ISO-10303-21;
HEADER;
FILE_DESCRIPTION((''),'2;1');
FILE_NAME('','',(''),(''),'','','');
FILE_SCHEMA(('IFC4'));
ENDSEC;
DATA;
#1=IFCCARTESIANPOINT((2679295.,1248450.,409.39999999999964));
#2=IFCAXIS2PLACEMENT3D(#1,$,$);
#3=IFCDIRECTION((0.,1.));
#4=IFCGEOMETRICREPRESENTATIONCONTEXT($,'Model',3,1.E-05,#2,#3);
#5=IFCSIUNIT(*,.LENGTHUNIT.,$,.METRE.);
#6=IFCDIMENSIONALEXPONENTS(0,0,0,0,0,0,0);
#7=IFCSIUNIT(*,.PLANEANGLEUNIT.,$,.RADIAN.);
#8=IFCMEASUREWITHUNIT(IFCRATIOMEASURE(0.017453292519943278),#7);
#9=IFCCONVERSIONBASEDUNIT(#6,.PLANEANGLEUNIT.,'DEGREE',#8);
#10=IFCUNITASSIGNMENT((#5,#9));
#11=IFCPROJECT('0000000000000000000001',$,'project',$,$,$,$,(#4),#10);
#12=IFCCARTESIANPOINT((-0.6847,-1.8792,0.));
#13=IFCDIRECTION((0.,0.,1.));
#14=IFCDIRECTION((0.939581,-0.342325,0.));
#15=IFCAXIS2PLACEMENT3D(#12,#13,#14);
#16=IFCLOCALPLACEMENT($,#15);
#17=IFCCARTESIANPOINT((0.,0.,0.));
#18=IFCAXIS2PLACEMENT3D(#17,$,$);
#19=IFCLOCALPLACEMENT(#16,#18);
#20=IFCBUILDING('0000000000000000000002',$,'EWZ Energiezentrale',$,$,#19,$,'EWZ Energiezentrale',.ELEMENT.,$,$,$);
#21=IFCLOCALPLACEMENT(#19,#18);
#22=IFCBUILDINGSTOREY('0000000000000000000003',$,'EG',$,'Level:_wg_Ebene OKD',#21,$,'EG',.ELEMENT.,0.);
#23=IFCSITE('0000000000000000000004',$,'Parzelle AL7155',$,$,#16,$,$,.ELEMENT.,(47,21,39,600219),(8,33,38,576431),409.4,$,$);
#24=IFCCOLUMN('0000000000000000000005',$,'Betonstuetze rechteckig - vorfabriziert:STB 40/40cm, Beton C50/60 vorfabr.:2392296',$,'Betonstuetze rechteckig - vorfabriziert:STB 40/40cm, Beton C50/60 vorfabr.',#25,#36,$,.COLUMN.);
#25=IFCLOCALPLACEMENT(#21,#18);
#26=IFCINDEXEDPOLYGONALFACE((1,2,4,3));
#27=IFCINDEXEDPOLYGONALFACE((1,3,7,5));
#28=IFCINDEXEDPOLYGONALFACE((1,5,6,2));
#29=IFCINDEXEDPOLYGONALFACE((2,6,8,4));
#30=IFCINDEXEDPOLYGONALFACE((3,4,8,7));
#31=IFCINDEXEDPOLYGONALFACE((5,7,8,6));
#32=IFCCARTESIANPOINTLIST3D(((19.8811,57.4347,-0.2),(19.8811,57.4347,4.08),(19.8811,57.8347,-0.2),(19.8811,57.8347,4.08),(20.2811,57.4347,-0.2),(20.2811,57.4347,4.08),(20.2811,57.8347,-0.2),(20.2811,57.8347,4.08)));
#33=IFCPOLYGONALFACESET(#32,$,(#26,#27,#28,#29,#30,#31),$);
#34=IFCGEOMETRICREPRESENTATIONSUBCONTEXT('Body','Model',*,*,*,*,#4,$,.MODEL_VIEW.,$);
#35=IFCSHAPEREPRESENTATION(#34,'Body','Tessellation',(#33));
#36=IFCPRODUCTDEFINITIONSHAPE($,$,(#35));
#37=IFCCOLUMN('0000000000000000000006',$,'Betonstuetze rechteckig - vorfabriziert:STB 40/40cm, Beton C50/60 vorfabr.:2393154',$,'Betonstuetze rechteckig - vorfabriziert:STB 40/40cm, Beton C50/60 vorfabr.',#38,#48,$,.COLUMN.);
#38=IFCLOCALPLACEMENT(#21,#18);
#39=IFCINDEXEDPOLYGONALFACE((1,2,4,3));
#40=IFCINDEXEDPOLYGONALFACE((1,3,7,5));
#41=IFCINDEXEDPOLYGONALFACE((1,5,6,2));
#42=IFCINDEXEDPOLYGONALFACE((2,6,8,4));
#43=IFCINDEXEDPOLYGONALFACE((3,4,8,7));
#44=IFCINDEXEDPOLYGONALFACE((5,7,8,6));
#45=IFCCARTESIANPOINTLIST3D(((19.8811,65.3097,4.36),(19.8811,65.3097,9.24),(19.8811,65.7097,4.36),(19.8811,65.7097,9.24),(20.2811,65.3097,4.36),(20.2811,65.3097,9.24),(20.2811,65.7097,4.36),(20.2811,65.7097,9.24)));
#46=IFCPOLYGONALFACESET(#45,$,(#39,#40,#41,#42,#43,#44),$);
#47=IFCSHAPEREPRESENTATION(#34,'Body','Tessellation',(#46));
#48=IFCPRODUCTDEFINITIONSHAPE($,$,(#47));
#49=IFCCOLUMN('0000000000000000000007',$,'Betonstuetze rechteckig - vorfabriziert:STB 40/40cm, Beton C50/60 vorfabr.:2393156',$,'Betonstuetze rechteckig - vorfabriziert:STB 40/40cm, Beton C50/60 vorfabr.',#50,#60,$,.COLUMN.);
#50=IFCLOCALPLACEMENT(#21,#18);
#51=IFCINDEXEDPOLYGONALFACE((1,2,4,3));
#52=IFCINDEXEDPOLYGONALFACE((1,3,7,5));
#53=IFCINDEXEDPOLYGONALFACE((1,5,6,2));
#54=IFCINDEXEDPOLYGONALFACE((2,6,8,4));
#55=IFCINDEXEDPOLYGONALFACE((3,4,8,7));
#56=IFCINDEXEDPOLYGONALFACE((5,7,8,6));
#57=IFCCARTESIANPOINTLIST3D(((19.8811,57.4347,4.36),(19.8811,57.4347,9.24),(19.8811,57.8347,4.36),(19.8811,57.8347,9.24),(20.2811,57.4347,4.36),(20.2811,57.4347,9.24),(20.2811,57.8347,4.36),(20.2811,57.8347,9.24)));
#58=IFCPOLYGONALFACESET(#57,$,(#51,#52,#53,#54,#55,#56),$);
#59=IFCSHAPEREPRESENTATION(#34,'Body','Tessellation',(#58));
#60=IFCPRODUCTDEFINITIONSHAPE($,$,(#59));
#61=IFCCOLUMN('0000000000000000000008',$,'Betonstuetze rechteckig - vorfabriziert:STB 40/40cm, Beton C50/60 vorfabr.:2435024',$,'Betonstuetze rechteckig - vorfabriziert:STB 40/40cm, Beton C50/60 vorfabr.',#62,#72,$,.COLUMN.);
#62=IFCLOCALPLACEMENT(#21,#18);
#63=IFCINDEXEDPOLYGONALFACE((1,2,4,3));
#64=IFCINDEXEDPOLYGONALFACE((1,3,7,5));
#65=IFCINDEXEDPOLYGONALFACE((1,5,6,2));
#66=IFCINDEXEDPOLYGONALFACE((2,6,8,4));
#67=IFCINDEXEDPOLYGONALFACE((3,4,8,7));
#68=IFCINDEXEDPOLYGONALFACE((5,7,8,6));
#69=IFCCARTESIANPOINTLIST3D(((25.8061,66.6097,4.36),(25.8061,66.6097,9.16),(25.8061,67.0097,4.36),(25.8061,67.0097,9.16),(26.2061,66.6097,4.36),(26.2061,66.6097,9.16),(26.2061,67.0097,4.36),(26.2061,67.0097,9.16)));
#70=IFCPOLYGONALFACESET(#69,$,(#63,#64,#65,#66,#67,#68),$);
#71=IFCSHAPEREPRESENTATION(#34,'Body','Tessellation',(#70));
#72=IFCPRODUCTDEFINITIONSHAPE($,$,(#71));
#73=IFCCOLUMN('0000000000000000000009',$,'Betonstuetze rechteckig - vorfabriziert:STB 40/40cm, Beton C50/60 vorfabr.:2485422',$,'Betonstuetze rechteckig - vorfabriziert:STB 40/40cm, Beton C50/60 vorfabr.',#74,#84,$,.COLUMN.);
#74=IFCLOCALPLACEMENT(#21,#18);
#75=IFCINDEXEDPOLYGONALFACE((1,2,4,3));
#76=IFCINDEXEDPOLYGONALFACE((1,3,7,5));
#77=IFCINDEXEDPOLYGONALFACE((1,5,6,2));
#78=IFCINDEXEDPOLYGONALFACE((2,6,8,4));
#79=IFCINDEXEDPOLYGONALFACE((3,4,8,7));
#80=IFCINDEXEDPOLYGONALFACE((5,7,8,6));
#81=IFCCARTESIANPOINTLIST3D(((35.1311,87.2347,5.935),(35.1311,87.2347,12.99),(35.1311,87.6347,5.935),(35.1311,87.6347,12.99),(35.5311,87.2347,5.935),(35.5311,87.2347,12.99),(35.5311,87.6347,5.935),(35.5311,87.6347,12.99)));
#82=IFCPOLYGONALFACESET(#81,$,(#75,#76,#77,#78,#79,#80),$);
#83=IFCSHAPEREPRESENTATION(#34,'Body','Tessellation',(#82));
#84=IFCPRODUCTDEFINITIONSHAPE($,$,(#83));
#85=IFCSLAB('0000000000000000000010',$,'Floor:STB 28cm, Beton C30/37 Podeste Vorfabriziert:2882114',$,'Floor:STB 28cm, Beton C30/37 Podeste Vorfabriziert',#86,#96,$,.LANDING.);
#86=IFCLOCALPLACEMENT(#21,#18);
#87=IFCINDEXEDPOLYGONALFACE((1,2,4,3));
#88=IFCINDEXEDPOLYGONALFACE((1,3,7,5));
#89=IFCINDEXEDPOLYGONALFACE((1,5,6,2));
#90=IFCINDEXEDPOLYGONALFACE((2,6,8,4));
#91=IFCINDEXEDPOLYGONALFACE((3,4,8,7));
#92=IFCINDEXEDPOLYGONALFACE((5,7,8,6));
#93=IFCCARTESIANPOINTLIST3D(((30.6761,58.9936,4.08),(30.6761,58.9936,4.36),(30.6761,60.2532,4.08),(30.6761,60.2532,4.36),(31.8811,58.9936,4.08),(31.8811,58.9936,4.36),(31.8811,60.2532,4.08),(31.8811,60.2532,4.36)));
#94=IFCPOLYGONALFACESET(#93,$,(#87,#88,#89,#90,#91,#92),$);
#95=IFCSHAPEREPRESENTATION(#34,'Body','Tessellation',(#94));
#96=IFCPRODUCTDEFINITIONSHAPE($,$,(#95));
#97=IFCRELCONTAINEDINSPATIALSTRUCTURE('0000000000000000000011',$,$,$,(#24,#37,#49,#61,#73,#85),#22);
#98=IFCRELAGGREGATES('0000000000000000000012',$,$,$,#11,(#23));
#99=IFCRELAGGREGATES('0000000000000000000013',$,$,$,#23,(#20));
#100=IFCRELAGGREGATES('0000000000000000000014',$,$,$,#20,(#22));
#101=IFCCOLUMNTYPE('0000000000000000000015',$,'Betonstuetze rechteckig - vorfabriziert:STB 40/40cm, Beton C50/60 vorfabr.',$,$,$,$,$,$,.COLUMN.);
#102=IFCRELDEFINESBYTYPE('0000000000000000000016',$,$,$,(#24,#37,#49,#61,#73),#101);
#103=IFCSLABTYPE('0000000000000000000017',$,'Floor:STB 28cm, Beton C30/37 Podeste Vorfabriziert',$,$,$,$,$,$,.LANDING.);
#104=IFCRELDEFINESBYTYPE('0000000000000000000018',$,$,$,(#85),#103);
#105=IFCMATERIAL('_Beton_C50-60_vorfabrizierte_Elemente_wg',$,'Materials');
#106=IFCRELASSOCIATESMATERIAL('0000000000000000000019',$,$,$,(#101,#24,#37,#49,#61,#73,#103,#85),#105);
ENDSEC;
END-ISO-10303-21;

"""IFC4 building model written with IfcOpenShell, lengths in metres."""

from ifc_helpers import new_model, entity, si_unit, converted_unit, direction, frame, origin, place, context, subcontext, project, spatial, indexed_curve, outline, extrude, source, transform, mapped, material, type_object, element, save


model = new_model("IFC4")

# Units and contexts
model_context = context("Model", 3, precision=1e-05, world=frame((2679295.0, 1248450.0, 409.39999999999964)), true_north=direction((0.0, 1.0)))
body_context = subcontext(model_context, "Body", "Model", "MODEL_VIEW")
ifc_project = project(units=[si_unit("LENGTHUNIT", "METRE"), converted_unit("PLANEANGLEUNIT", "DEGREE", entity("IfcRatioMeasure", 0.017453292519943278), si_unit("PLANEANGLEUNIT", "RADIAN"), dimensions=[0, 0, 0, 0, 0, 0, 0])], contexts=[model_context])

# Site, building, storey
site_placement = place(None, frame((-0.6847, -1.8792, 0.0), z_axis=(0.0, 0.0, 1.0), x_axis=(0.939581, -0.342325, 0.0)))
site = spatial("IfcSite", under=ifc_project, at=site_placement, Name="Parzelle AL7155", CompositionType="ELEMENT", RefLatitude=(47, 21, 39, 600219), RefLongitude=(8, 33, 38, 576431), RefElevation=409.4)
building_placement = place(site_placement, origin())
building = spatial("IfcBuilding", under=site, at=building_placement, Name="EWZ Energiezentrale", LongName="EWZ Energiezentrale", CompositionType="ELEMENT")
storey_placement = place(building_placement, origin())
storey = spatial("IfcBuildingStorey", under=building, at=storey_placement, Name="EG", ObjectType="Level:_wg_Ebene OKD", LongName="EG", CompositionType="ELEMENT", Elevation=0.0)

# Columns
ifc_material_1 = material(Name="_Beton_C50-60_vorfabrizierte_Elemente_wg", Category="Materials")
column_type = type_object("IfcColumnType", Name="Betonstuetze rechteckig - vorfabriziert:STB 40/40cm, Beton C50/60 vorfabr.", PredefinedType="COLUMN", material=ifc_material_1)
shared_shape_1 = source(origin(), body_context, "Body", "SweptSolid", [
    extrude(outline(indexed_curve([(-0.2, -0.2), (0.2, -0.2), (0.2, 0.2), (-0.2, 0.2), (-0.2, -0.2)], self_intersect=False)), frame((20.0811, 57.6347, -0.2), z_axis=(0.0, 0.0, 1.0), x_axis=(0.0, -1.0, 0.0)), (0.0, 0.0, 1.0), 4.28),
])
column_1_placement = place(storey_placement, origin())
element("IfcColumn", 1, at=column_1_placement, inside=storey, type_object=column_type, material=ifc_material_1, Name="Betonstuetze rechteckig - vorfabriziert:STB 40/40cm, Beton C50/60 vorfabr.:2392296", ObjectType="Betonstuetze rechteckig - vorfabriziert:STB 40/40cm, Beton C50/60 vorfabr.", PredefinedType="COLUMN", context=body_context, shape_type="MappedRepresentation", body=[
    mapped(shared_shape_1, transform((0.0, 0.0, 0.0), scale=1.0)),
])
shared_shape_2 = source(origin(), body_context, "Body", "SweptSolid", [
    extrude(outline(indexed_curve([(-0.2, -0.2), (0.2, -0.2), (0.2, 0.2), (-0.2, 0.2), (-0.2, -0.2)], self_intersect=False)), frame((20.0811, 65.5097, 4.36), z_axis=(0.0, 0.0, 1.0), x_axis=(-1.0, 0.0, 0.0)), (0.0, 0.0, 1.0), 4.88),
])
column_2_placement = place(storey_placement, frame((0.0, 0.0, 0.0), z_axis=(0.0, 0.0, 1.0), x_axis=(1.0, 0.0, 0.0)))
element("IfcColumn", 2, at=column_2_placement, inside=storey, type_object=column_type, material=ifc_material_1, Name="Betonstuetze rechteckig - vorfabriziert:STB 40/40cm, Beton C50/60 vorfabr.:2393154", ObjectType="Betonstuetze rechteckig - vorfabriziert:STB 40/40cm, Beton C50/60 vorfabr.", PredefinedType="COLUMN", context=body_context, shape_type="MappedRepresentation", body=[
    mapped(shared_shape_2, transform((0.0, 0.0, 0.0), scale=1.0)),
])
shared_shape_3 = source(origin(), body_context, "Body", "SweptSolid", [
    extrude(outline(indexed_curve([(-0.2, -0.2), (0.2, -0.2), (0.2, 0.2), (-0.2, 0.2), (-0.2, -0.2)], self_intersect=False)), frame((20.0811, 57.6347, 4.36), z_axis=(0.0, 0.0, 1.0), x_axis=(0.0, -1.0, 0.0)), (0.0, 0.0, 1.0), 4.88),
])
column_3_placement = place(storey_placement, frame((0.0, 0.0, 0.0), z_axis=(0.0, 0.0, 1.0), x_axis=(1.0, 0.0, 0.0)))
element("IfcColumn", 3, at=column_3_placement, inside=storey, type_object=column_type, material=ifc_material_1, Name="Betonstuetze rechteckig - vorfabriziert:STB 40/40cm, Beton C50/60 vorfabr.:2393156", ObjectType="Betonstuetze rechteckig - vorfabriziert:STB 40/40cm, Beton C50/60 vorfabr.", PredefinedType="COLUMN", context=body_context, shape_type="MappedRepresentation", body=[
    mapped(shared_shape_3, transform((0.0, 0.0, 0.0), scale=1.0)),
])
shared_shape_4 = source(origin(), body_context, "Body", "SweptSolid", [
    extrude(outline(indexed_curve([(-0.2, -0.2), (0.2, -0.2), (0.2, 0.2), (-0.2, 0.2), (-0.2, -0.2)], self_intersect=False)), frame((26.0061, 66.8097, 4.36), z_axis=(0.0, 0.0, 1.0), x_axis=(-1.0, 0.0, 0.0)), (0.0, 0.0, 1.0), 4.8),
])
column_4_placement = place(storey_placement, frame((0.0, 0.0, 0.0), z_axis=(0.0, 0.0, 1.0), x_axis=(1.0, 0.0, 0.0)))
element("IfcColumn", 4, at=column_4_placement, inside=storey, type_object=column_type, material=ifc_material_1, Name="Betonstuetze rechteckig - vorfabriziert:STB 40/40cm, Beton C50/60 vorfabr.:2435024", ObjectType="Betonstuetze rechteckig - vorfabriziert:STB 40/40cm, Beton C50/60 vorfabr.", PredefinedType="COLUMN", context=body_context, shape_type="MappedRepresentation", body=[
    mapped(shared_shape_4, transform((0.0, 0.0, 0.0), scale=1.0)),
])
shared_shape_5 = source(origin(), body_context, "Body", "SweptSolid", [
    extrude(outline(indexed_curve([(-0.2, -0.2), (0.2, -0.2), (0.2, 0.2), (-0.2, 0.2), (-0.2, -0.2)], self_intersect=False)), frame((35.3311, 87.4347, 5.935), z_axis=(0.0, 0.0, 1.0), x_axis=(0.0, -1.0, 0.0)), (0.0, 0.0, 1.0), 7.055),
])
column_5_placement = place(storey_placement, frame((0.0, 0.0, 0.0), z_axis=(0.0, 0.0, 1.0), x_axis=(1.0, 0.0, 0.0)))
element("IfcColumn", 5, at=column_5_placement, inside=storey, type_object=column_type, material=ifc_material_1, Name="Betonstuetze rechteckig - vorfabriziert:STB 40/40cm, Beton C50/60 vorfabr.:2485422", ObjectType="Betonstuetze rechteckig - vorfabriziert:STB 40/40cm, Beton C50/60 vorfabr.", PredefinedType="COLUMN", context=body_context, shape_type="MappedRepresentation", body=[
    mapped(shared_shape_5, transform((0.0, 0.0, 0.0), scale=1.0)),
])

# Slab
slab_type_1 = type_object("IfcSlabType", Name="Floor:STB 28cm, Beton C30/37 Podeste Vorfabriziert", PredefinedType="LANDING", material=ifc_material_1)
slab_1_placement = place(storey_placement, frame((0.0, 0.0, 0.0), z_axis=(0.0, 0.0, 1.0), x_axis=(1.0, 0.0, 0.0)))
element("IfcSlab", 6, at=slab_1_placement, inside=storey, type_object=slab_type_1, material=ifc_material_1, Name="Floor:STB 28cm, Beton C30/37 Podeste Vorfabriziert:2882114", ObjectType="Floor:STB 28cm, Beton C30/37 Podeste Vorfabriziert", PredefinedType="LANDING", context=body_context, shape_type="SweptSolid", body=[
    extrude(outline(indexed_curve([(-0.6298, -0.6025), (0.6298, -0.6025), (0.6298, 0.6025), (-0.6298, 0.6025), (-0.6298, -0.6025)], self_intersect=False)), frame((31.2786, 59.6234, 4.36), z_axis=(0.0, 0.0, -1.0), x_axis=(0.0, 1.0, 0.0)), (0.0, 0.0, 1.0), 0.28),
])

save(model, "model.ifc")
